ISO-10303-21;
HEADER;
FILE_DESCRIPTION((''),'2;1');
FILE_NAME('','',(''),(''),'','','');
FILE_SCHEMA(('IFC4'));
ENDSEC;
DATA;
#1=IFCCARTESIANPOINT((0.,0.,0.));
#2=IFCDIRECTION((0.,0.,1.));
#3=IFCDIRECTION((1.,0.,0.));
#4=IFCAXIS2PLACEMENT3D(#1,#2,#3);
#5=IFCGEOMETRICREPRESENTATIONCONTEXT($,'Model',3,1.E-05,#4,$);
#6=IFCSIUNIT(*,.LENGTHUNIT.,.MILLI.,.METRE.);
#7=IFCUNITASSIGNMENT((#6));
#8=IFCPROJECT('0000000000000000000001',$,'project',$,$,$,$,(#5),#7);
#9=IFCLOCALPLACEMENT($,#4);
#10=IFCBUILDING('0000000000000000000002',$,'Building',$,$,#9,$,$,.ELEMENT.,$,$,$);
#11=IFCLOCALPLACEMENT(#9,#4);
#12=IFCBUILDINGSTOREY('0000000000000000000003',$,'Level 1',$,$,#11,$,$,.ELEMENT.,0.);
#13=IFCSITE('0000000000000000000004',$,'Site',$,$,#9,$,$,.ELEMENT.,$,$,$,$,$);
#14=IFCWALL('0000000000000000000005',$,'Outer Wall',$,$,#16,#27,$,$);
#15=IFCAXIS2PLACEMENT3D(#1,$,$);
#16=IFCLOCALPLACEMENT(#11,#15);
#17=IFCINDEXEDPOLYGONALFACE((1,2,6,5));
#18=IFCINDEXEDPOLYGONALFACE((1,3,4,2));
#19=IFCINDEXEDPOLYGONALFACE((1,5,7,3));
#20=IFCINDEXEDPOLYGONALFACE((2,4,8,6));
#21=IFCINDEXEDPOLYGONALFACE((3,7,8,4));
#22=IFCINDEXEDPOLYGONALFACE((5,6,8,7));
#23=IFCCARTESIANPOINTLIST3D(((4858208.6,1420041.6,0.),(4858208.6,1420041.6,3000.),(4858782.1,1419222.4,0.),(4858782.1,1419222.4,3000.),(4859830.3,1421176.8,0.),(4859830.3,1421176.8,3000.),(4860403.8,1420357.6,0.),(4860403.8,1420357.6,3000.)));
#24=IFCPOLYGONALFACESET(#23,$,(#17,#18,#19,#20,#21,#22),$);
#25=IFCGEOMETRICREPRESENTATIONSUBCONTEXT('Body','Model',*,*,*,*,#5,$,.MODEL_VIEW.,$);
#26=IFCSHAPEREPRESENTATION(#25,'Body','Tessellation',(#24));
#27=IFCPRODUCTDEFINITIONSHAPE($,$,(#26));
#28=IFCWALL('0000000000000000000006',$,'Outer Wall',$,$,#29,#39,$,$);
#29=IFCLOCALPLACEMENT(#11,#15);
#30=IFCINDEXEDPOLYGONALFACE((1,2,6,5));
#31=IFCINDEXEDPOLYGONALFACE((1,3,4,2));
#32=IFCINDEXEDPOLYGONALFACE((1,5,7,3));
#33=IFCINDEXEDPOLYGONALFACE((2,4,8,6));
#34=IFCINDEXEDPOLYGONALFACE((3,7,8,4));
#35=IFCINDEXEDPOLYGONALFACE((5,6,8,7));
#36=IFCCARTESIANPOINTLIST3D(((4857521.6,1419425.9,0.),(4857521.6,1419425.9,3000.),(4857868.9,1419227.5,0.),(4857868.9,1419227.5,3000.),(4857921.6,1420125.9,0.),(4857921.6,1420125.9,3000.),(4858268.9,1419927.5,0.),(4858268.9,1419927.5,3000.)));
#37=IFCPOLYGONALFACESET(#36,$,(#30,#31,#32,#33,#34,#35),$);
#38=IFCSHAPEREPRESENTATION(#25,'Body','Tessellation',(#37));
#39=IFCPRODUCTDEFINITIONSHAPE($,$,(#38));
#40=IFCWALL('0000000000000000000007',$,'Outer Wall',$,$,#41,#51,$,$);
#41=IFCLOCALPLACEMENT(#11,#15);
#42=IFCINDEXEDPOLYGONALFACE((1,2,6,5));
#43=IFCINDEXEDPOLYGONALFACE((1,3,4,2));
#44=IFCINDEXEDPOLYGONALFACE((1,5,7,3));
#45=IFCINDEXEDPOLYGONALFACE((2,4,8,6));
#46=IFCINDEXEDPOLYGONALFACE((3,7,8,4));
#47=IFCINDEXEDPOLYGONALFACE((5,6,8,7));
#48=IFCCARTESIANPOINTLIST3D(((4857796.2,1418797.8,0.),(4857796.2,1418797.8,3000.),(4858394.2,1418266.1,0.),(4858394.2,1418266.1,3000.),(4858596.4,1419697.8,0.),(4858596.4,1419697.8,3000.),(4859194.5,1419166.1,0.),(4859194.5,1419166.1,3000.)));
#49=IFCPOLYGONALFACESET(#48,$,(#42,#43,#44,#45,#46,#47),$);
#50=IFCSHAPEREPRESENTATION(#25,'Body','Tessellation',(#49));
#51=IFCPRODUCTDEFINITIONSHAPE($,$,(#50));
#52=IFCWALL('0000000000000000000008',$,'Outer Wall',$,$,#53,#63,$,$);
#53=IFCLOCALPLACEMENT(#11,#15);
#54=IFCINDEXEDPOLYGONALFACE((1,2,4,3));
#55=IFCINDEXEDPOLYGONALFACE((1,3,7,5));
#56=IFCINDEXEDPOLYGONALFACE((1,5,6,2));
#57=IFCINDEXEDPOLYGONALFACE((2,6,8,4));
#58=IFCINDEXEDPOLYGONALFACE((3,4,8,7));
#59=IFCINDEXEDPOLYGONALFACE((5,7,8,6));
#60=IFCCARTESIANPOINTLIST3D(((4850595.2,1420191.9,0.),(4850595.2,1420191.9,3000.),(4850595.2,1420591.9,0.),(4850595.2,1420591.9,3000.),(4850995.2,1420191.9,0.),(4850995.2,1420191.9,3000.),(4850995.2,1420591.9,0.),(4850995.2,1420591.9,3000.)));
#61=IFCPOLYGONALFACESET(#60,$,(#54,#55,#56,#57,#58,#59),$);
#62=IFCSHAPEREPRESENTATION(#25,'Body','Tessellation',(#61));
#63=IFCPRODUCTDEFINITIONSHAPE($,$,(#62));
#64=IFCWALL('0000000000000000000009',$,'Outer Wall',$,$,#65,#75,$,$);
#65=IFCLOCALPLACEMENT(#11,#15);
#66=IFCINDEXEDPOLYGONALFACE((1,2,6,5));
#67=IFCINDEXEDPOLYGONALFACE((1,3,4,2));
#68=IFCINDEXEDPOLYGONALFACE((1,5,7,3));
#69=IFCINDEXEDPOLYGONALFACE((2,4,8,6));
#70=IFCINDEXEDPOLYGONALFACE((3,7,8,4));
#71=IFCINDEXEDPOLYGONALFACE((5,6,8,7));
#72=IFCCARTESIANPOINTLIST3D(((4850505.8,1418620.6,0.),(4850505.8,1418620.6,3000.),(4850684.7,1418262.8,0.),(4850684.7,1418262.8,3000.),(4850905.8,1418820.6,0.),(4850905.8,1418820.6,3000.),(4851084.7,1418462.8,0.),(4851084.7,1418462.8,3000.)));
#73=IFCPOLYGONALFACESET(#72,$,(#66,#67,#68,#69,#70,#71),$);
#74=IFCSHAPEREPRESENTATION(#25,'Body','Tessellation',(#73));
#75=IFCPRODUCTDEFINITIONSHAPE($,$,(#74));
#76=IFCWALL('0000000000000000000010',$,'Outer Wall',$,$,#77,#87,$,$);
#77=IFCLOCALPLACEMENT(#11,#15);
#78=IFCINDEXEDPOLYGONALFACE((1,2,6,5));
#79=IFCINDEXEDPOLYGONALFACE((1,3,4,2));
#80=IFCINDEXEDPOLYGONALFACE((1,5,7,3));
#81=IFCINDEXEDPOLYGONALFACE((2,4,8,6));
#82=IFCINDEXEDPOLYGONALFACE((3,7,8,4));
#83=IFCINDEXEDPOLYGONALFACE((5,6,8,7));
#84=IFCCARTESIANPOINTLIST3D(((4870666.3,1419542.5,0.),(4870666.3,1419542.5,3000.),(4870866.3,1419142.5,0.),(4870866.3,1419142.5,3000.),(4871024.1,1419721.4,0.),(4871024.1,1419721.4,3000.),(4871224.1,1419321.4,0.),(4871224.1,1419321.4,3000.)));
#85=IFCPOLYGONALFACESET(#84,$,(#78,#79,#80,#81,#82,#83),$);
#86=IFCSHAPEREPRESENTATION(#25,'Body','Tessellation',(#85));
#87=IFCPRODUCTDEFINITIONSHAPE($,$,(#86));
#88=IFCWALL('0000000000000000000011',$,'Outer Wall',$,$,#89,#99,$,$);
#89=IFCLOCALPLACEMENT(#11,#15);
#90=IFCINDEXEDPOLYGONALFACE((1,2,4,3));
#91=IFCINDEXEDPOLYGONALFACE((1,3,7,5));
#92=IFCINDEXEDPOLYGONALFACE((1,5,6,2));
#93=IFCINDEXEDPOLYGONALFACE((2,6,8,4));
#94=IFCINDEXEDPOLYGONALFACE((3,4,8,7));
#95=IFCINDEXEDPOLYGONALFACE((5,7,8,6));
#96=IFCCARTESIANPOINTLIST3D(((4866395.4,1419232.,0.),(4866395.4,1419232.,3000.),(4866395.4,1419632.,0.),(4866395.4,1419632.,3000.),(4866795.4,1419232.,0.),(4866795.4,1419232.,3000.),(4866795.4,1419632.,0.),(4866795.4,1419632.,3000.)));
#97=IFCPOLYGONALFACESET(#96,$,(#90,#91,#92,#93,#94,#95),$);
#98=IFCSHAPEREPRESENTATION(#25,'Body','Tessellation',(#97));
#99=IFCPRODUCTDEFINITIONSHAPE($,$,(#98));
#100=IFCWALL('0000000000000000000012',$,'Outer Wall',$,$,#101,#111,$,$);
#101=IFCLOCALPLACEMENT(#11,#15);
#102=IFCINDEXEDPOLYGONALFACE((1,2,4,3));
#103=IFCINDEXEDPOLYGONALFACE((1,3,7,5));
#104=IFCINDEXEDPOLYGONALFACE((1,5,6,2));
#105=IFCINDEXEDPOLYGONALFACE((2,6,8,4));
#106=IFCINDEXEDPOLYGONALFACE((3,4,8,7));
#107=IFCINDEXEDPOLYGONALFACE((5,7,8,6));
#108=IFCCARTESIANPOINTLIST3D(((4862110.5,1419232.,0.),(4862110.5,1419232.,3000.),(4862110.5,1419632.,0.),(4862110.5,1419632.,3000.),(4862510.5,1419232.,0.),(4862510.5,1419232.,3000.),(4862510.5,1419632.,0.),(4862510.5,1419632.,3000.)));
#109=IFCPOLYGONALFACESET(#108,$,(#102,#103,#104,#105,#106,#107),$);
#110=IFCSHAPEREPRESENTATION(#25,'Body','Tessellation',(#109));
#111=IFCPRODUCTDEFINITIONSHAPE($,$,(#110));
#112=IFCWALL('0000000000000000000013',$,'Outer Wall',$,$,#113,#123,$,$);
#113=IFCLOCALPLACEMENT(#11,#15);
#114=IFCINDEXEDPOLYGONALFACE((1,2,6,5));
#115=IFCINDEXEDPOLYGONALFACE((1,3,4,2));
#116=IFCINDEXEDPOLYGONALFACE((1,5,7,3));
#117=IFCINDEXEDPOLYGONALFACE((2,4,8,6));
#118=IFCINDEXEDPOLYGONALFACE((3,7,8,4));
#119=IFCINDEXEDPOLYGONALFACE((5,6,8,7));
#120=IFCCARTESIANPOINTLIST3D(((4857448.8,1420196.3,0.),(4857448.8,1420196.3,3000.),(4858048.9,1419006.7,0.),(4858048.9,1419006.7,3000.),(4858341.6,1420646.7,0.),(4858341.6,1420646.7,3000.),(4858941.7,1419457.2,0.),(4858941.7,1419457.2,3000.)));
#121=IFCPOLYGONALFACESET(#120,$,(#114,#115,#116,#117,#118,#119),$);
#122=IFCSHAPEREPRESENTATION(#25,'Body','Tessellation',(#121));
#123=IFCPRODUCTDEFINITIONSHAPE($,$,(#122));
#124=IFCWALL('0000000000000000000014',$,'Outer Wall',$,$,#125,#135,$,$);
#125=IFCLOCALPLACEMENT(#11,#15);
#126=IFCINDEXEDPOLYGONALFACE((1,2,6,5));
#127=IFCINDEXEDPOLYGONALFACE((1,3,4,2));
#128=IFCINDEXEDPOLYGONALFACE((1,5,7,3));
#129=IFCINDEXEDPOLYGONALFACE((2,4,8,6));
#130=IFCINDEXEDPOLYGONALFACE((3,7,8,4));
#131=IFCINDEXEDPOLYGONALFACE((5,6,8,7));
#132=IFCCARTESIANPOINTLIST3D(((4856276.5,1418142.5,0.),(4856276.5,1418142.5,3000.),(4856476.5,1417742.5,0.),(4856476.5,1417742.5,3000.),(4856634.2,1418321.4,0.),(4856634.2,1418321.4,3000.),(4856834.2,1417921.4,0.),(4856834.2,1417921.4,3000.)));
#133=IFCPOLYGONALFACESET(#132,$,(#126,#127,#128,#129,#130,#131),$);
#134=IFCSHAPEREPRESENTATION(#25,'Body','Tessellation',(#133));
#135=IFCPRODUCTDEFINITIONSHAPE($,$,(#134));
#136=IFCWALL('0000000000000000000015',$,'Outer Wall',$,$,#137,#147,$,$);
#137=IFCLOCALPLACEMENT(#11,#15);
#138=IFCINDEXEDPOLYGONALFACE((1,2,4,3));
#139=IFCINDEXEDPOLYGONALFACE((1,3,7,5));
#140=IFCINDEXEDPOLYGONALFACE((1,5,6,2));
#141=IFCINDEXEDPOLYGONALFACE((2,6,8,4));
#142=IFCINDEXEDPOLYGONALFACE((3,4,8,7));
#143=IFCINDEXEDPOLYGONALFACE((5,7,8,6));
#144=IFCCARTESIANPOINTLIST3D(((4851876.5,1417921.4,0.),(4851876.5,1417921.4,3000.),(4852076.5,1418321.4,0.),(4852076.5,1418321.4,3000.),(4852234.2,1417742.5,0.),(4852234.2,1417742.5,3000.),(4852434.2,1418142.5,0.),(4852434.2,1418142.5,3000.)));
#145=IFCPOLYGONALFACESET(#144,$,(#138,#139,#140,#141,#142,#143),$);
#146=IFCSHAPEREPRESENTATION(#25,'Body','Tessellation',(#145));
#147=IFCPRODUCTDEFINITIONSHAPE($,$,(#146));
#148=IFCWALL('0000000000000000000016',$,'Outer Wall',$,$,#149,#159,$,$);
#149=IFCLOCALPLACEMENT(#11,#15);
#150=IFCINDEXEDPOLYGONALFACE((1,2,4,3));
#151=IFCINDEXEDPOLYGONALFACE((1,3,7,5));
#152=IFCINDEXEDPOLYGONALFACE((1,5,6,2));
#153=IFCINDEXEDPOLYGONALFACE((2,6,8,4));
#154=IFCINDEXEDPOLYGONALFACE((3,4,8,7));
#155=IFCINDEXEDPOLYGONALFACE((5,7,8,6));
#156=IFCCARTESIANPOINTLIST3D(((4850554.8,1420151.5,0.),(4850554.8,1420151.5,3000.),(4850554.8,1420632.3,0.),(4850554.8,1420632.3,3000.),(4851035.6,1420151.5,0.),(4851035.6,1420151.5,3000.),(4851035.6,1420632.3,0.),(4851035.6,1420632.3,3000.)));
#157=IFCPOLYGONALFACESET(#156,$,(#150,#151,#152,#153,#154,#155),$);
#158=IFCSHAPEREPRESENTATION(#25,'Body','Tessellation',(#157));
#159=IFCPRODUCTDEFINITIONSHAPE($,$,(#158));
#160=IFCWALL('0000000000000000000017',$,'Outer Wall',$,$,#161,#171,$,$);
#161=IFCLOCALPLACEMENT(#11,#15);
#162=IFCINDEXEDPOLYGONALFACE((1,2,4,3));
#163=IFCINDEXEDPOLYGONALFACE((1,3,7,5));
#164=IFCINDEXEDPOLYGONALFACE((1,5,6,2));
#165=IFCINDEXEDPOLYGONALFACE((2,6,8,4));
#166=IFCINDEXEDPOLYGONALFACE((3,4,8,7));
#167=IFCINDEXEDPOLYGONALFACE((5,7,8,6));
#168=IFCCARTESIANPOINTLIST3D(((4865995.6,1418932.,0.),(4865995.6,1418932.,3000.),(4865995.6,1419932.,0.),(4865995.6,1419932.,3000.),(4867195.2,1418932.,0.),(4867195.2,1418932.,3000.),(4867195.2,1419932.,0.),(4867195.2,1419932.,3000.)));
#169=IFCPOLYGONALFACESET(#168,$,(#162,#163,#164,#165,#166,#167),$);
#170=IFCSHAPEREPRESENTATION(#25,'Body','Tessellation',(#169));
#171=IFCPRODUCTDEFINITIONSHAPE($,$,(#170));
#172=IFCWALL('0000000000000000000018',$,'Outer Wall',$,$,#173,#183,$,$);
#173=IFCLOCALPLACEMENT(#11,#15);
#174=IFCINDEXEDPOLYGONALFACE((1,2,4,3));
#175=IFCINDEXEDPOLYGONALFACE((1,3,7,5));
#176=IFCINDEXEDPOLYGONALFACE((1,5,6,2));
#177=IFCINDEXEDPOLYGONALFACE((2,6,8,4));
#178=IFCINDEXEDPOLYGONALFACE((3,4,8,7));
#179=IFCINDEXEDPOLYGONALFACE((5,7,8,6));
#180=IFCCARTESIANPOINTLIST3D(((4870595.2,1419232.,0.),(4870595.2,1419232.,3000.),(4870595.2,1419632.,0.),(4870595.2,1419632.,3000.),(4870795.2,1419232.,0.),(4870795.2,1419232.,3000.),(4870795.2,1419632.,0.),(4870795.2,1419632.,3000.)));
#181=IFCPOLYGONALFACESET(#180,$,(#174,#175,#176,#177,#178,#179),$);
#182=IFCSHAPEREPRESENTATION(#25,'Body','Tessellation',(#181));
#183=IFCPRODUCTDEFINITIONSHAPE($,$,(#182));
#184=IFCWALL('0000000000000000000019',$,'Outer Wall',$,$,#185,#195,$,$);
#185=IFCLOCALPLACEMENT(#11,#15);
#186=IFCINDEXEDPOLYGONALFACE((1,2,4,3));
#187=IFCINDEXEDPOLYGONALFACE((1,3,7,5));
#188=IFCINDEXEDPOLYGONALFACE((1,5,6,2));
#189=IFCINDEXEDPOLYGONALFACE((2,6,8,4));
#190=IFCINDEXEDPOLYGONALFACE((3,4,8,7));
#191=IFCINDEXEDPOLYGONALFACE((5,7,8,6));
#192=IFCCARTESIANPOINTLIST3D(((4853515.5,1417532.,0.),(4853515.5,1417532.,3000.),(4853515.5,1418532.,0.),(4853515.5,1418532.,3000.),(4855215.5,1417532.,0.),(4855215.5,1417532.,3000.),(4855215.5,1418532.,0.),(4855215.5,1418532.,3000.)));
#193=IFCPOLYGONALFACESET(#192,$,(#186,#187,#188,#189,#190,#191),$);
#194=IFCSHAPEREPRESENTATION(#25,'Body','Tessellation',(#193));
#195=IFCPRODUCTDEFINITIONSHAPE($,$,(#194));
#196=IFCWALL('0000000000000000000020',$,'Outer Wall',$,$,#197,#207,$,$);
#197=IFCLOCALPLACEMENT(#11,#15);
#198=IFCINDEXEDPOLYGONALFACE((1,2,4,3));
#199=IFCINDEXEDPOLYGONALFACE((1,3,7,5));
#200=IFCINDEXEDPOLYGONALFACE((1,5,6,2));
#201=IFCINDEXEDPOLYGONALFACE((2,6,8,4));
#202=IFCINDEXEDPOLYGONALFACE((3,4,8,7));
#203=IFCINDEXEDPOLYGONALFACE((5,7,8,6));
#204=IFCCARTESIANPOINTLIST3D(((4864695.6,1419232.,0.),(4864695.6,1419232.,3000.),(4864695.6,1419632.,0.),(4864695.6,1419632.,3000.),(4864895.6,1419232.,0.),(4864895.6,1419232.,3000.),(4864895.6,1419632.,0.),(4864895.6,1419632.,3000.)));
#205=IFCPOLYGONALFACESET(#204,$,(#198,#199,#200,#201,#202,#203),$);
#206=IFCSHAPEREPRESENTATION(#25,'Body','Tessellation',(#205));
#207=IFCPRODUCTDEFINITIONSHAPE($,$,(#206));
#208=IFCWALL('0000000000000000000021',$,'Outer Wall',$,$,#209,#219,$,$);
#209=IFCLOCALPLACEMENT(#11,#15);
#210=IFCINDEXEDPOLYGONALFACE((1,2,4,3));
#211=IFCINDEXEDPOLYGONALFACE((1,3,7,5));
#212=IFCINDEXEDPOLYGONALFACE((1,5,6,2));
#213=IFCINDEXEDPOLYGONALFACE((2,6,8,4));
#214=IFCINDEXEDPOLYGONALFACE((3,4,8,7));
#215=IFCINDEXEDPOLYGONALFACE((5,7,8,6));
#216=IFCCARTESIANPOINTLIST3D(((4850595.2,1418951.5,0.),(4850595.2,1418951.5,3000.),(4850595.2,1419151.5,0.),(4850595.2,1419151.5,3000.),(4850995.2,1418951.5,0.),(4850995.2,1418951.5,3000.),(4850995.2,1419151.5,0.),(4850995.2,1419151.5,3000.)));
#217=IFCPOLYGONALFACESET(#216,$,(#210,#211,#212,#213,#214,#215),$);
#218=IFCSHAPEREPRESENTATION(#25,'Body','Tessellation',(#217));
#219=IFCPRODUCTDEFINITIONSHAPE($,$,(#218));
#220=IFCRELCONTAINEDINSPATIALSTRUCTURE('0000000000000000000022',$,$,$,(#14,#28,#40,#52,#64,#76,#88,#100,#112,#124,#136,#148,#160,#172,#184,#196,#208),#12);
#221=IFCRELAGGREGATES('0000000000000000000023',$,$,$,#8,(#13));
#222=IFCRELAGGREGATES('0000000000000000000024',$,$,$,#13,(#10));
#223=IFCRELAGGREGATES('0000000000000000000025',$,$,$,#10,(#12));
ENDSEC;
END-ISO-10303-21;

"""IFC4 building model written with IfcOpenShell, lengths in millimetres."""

from ifc_helpers import new_model, si_unit, frame, frame_2d, origin_with_axes, place, context, subcontext, project, spatial, rectangle, extrude, element, save


model = new_model("IFC4")

# Units and contexts
model_context = context("Model", 3, precision=1e-05, world=origin_with_axes())
body_context = subcontext(model_context, "Body", "Model", "MODEL_VIEW")
ifc_project = project(units=[si_unit("LENGTHUNIT", "METRE", prefix="MILLI")], contexts=[model_context])

# Site, building, storey
placement = place(None, origin_with_axes())
site = spatial("IfcSite", under=ifc_project, at=placement, Name="Site", CompositionType="ELEMENT")
building = spatial("IfcBuilding", under=site, at=placement, Name="Building", CompositionType="ELEMENT")
storey_placement = place(placement, origin_with_axes())
storey = spatial("IfcBuildingStorey", under=building, at=storey_placement, Name="Level 1", CompositionType="ELEMENT", Elevation=0.0)

# Walls
wall_1_placement = place(placement, frame((4860117.0, 1420767.2, 0.0), z_axis=(0.0, 0.0, 1.0), x_axis=(-0.819208, -0.573496, 0.0)))
element("IfcWall", 1, at=wall_1_placement, inside=storey, Name="Outer Wall", context=body_context, shape_type="SweptSolid", body=[
    extrude(rectangle(XDim=1979.6, YDim=1000.0, at=frame_2d((989.8, 0.0), x_axis=(1.0, 0.0))), origin_with_axes(), (0.0, 0.0, 1.0), 3000.0),
])
wall_2_placement = place(placement, frame((4857695.2, 1419326.7, 0.0), z_axis=(0.0, 0.0, 1.0), x_axis=(0.496139, 0.868243, 0.0)))
element("IfcWall", 2, at=wall_2_placement, inside=storey, Name="Outer Wall", context=body_context, shape_type="SweptSolid", body=[
    extrude(rectangle(XDim=806.2, YDim=400.0, at=frame_2d((403.1, 0.0), x_axis=(1.0, 0.0))), origin_with_axes(), (0.0, 0.0, 1.0), 3000.0),
])
wall_3_placement = place(placement, frame((4858095.2, 1418532.0, 0.0), z_axis=(0.0, 0.0, 1.0), x_axis=(0.664471, 0.747314, 0.0)))
element("IfcWall", 3, at=wall_3_placement, inside=storey, Name="Outer Wall", context=body_context, shape_type="SweptSolid", body=[
    extrude(rectangle(XDim=1204.3, YDim=800.2, at=frame_2d((602.2, 0.0), x_axis=(1.0, 0.0))), origin_with_axes(), (0.0, 0.0, 1.0), 3000.0),
])
wall_4_placement = place(placement, frame((4850995.2, 1420391.9, 0.0), z_axis=(0.0, 0.0, 1.0), x_axis=(-1.0, 0.0, 0.0)))
element("IfcWall", 4, at=wall_4_placement, inside=storey, Name="Outer Wall", context=body_context, shape_type="SweptSolid", body=[
    extrude(rectangle(XDim=400.0, YDim=400.0, at=frame_2d((200.0, 0.0), x_axis=(1.0, 0.0))), origin_with_axes(), (0.0, 0.0, 1.0), 3000.0),
])
for number, where, z_axis, x_axis, name in (
    (5, (4850995.2, 1418641.7, 0.0), (0.0, 0.0, 1.0), (-0.894427, -0.447214, 0.0), "Outer Wall"),
    (6, (4870845.2, 1419632.0, 0.0), (0.0, 0.0, 1.0), (0.447214, -0.894427, 0.0), "Outer Wall"),
):
    element("IfcWall", number, at=place(placement, frame(where, z_axis=z_axis, x_axis=x_axis)), inside=storey, Name=name, context=body_context, shape_type="SweptSolid", body=[
        extrude(rectangle(XDim=447.2, YDim=400.0, at=frame_2d((223.6, 0.0), x_axis=(1.0, 0.0))), origin_with_axes(), (0.0, 0.0, 1.0), 3000.0),
    ])
for number, where, z_axis, x_axis, name in (
    (7, (4866595.4, 1419632.0, 0.0), (0.0, 0.0, 1.0), (0.0, -1.0, 0.0), "Outer Wall"),
    (8, (4862310.5, 1419632.0, 0.0), (0.0, 0.0, 1.0), (0.0, -1.0, 0.0), "Outer Wall"),
):
    element("IfcWall", number, at=place(placement, frame(where, z_axis=z_axis, x_axis=x_axis)), inside=storey, Name=name, context=body_context, shape_type="SweptSolid", body=[
        extrude(rectangle(XDim=400.0, YDim=400.0, at=frame_2d((200.0, 0.0), x_axis=(1.0, 0.0))), origin_with_axes(), (0.0, 0.0, 1.0), 3000.0),
    ])
wall_5_placement = place(placement, frame((4858495.3, 1419232.0, 0.0), z_axis=(0.0, 0.0, 1.0), x_axis=(-0.450431, 0.892811, 0.0)))
element("IfcWall", 9, at=wall_5_placement, inside=storey, Name="Outer Wall", context=body_context, shape_type="SweptSolid", body=[
    extrude(rectangle(XDim=1332.3, YDim=1000.0, at=frame_2d((666.2, 0.0), x_axis=(1.0, 0.0))), origin_with_axes(), (0.0, 0.0, 1.0), 3000.0),
])
for number, where, z_axis, x_axis, name in (
    (10, (4856455.4, 1418232.0, 0.0), (0.0, 0.0, 1.0), (0.447214, -0.894427, 0.0), "Outer Wall"),
    (11, (4852255.4, 1418232.0, 0.0), (0.0, 0.0, 1.0), (-0.447214, -0.894427, 0.0), "Outer Wall"),
):
    element("IfcWall", number, at=place(placement, frame(where, z_axis=z_axis, x_axis=x_axis)), inside=storey, Name=name, context=body_context, shape_type="SweptSolid", body=[
        extrude(rectangle(XDim=447.2, YDim=400.0, at=frame_2d((223.6, 0.0), x_axis=(1.0, 0.0))), origin_with_axes(), (0.0, 0.0, 1.0), 3000.0),
    ])
wall_6_placement = place(placement, frame((4850795.2, 1420632.3, 0.0), z_axis=(0.0, 0.0, 1.0), x_axis=(0.0, -1.0, 0.0)))
element("IfcWall", 12, at=wall_6_placement, inside=storey, Name="Outer Wall", context=body_context, shape_type="SweptSolid", body=[
    extrude(rectangle(XDim=480.8, YDim=480.8, at=frame_2d((240.4, 0.0), x_axis=(1.0, 0.0))), origin_with_axes(), (0.0, 0.0, 1.0), 3000.0),
])
wall_7_placement = place(placement, frame((4867195.2, 1419432.0, 0.0), z_axis=(0.0, 0.0, 1.0), x_axis=(-1.0, 0.0, 0.0)))
element("IfcWall", 13, at=wall_7_placement, inside=storey, Name="Outer Wall", context=body_context, shape_type="SweptSolid", body=[
    extrude(rectangle(XDim=1199.6, YDim=1000.0, at=frame_2d((599.8, 0.0), x_axis=(1.0, 0.0))), origin_with_axes(), (0.0, 0.0, 1.0), 3000.0),
])
wall_8_placement = place(placement, frame((4870695.2, 1419232.0, 0.0), z_axis=(0.0, 0.0, 1.0), x_axis=(0.0, 1.0, 0.0)))
element("IfcWall", 14, at=wall_8_placement, inside=storey, Name="Outer Wall", context=body_context, shape_type="SweptSolid", body=[
    extrude(rectangle(XDim=400.0, YDim=200.0, at=frame_2d((200.0, 0.0), x_axis=(1.0, 0.0))), origin_with_axes(), (0.0, 0.0, 1.0), 3000.0),
])
wall_9_placement = place(placement, frame((4855215.5, 1418032.0, 0.0), z_axis=(0.0, 0.0, 1.0), x_axis=(-1.0, 0.0, 0.0)))
element("IfcWall", 15, at=wall_9_placement, inside=storey, Name="Outer Wall", context=body_context, shape_type="SweptSolid", body=[
    extrude(rectangle(XDim=1700.0, YDim=1000.0, at=frame_2d((850.0, 0.0), x_axis=(1.0, 0.0))), origin_with_axes(), (0.0, 0.0, 1.0), 3000.0),
])
for number, where, z_axis, x_axis, name in (
    (16, (4864795.6, 1419232.0, 0.0), (0.0, 0.0, 1.0), (0.0, 1.0, 0.0), "Outer Wall"),
    (17, (4850995.2, 1419051.5, 0.0), (0.0, 0.0, 1.0), (-1.0, 0.0, 0.0), "Outer Wall"),
):
    element("IfcWall", number, at=place(placement, frame(where, z_axis=z_axis, x_axis=x_axis)), inside=storey, Name=name, context=body_context, shape_type="SweptSolid", body=[
        extrude(rectangle(XDim=400.0, YDim=200.0, at=frame_2d((200.0, 0.0), x_axis=(1.0, 0.0))), origin_with_axes(), (0.0, 0.0, 1.0), 3000.0),
    ])

save(model, "model.ifc")
